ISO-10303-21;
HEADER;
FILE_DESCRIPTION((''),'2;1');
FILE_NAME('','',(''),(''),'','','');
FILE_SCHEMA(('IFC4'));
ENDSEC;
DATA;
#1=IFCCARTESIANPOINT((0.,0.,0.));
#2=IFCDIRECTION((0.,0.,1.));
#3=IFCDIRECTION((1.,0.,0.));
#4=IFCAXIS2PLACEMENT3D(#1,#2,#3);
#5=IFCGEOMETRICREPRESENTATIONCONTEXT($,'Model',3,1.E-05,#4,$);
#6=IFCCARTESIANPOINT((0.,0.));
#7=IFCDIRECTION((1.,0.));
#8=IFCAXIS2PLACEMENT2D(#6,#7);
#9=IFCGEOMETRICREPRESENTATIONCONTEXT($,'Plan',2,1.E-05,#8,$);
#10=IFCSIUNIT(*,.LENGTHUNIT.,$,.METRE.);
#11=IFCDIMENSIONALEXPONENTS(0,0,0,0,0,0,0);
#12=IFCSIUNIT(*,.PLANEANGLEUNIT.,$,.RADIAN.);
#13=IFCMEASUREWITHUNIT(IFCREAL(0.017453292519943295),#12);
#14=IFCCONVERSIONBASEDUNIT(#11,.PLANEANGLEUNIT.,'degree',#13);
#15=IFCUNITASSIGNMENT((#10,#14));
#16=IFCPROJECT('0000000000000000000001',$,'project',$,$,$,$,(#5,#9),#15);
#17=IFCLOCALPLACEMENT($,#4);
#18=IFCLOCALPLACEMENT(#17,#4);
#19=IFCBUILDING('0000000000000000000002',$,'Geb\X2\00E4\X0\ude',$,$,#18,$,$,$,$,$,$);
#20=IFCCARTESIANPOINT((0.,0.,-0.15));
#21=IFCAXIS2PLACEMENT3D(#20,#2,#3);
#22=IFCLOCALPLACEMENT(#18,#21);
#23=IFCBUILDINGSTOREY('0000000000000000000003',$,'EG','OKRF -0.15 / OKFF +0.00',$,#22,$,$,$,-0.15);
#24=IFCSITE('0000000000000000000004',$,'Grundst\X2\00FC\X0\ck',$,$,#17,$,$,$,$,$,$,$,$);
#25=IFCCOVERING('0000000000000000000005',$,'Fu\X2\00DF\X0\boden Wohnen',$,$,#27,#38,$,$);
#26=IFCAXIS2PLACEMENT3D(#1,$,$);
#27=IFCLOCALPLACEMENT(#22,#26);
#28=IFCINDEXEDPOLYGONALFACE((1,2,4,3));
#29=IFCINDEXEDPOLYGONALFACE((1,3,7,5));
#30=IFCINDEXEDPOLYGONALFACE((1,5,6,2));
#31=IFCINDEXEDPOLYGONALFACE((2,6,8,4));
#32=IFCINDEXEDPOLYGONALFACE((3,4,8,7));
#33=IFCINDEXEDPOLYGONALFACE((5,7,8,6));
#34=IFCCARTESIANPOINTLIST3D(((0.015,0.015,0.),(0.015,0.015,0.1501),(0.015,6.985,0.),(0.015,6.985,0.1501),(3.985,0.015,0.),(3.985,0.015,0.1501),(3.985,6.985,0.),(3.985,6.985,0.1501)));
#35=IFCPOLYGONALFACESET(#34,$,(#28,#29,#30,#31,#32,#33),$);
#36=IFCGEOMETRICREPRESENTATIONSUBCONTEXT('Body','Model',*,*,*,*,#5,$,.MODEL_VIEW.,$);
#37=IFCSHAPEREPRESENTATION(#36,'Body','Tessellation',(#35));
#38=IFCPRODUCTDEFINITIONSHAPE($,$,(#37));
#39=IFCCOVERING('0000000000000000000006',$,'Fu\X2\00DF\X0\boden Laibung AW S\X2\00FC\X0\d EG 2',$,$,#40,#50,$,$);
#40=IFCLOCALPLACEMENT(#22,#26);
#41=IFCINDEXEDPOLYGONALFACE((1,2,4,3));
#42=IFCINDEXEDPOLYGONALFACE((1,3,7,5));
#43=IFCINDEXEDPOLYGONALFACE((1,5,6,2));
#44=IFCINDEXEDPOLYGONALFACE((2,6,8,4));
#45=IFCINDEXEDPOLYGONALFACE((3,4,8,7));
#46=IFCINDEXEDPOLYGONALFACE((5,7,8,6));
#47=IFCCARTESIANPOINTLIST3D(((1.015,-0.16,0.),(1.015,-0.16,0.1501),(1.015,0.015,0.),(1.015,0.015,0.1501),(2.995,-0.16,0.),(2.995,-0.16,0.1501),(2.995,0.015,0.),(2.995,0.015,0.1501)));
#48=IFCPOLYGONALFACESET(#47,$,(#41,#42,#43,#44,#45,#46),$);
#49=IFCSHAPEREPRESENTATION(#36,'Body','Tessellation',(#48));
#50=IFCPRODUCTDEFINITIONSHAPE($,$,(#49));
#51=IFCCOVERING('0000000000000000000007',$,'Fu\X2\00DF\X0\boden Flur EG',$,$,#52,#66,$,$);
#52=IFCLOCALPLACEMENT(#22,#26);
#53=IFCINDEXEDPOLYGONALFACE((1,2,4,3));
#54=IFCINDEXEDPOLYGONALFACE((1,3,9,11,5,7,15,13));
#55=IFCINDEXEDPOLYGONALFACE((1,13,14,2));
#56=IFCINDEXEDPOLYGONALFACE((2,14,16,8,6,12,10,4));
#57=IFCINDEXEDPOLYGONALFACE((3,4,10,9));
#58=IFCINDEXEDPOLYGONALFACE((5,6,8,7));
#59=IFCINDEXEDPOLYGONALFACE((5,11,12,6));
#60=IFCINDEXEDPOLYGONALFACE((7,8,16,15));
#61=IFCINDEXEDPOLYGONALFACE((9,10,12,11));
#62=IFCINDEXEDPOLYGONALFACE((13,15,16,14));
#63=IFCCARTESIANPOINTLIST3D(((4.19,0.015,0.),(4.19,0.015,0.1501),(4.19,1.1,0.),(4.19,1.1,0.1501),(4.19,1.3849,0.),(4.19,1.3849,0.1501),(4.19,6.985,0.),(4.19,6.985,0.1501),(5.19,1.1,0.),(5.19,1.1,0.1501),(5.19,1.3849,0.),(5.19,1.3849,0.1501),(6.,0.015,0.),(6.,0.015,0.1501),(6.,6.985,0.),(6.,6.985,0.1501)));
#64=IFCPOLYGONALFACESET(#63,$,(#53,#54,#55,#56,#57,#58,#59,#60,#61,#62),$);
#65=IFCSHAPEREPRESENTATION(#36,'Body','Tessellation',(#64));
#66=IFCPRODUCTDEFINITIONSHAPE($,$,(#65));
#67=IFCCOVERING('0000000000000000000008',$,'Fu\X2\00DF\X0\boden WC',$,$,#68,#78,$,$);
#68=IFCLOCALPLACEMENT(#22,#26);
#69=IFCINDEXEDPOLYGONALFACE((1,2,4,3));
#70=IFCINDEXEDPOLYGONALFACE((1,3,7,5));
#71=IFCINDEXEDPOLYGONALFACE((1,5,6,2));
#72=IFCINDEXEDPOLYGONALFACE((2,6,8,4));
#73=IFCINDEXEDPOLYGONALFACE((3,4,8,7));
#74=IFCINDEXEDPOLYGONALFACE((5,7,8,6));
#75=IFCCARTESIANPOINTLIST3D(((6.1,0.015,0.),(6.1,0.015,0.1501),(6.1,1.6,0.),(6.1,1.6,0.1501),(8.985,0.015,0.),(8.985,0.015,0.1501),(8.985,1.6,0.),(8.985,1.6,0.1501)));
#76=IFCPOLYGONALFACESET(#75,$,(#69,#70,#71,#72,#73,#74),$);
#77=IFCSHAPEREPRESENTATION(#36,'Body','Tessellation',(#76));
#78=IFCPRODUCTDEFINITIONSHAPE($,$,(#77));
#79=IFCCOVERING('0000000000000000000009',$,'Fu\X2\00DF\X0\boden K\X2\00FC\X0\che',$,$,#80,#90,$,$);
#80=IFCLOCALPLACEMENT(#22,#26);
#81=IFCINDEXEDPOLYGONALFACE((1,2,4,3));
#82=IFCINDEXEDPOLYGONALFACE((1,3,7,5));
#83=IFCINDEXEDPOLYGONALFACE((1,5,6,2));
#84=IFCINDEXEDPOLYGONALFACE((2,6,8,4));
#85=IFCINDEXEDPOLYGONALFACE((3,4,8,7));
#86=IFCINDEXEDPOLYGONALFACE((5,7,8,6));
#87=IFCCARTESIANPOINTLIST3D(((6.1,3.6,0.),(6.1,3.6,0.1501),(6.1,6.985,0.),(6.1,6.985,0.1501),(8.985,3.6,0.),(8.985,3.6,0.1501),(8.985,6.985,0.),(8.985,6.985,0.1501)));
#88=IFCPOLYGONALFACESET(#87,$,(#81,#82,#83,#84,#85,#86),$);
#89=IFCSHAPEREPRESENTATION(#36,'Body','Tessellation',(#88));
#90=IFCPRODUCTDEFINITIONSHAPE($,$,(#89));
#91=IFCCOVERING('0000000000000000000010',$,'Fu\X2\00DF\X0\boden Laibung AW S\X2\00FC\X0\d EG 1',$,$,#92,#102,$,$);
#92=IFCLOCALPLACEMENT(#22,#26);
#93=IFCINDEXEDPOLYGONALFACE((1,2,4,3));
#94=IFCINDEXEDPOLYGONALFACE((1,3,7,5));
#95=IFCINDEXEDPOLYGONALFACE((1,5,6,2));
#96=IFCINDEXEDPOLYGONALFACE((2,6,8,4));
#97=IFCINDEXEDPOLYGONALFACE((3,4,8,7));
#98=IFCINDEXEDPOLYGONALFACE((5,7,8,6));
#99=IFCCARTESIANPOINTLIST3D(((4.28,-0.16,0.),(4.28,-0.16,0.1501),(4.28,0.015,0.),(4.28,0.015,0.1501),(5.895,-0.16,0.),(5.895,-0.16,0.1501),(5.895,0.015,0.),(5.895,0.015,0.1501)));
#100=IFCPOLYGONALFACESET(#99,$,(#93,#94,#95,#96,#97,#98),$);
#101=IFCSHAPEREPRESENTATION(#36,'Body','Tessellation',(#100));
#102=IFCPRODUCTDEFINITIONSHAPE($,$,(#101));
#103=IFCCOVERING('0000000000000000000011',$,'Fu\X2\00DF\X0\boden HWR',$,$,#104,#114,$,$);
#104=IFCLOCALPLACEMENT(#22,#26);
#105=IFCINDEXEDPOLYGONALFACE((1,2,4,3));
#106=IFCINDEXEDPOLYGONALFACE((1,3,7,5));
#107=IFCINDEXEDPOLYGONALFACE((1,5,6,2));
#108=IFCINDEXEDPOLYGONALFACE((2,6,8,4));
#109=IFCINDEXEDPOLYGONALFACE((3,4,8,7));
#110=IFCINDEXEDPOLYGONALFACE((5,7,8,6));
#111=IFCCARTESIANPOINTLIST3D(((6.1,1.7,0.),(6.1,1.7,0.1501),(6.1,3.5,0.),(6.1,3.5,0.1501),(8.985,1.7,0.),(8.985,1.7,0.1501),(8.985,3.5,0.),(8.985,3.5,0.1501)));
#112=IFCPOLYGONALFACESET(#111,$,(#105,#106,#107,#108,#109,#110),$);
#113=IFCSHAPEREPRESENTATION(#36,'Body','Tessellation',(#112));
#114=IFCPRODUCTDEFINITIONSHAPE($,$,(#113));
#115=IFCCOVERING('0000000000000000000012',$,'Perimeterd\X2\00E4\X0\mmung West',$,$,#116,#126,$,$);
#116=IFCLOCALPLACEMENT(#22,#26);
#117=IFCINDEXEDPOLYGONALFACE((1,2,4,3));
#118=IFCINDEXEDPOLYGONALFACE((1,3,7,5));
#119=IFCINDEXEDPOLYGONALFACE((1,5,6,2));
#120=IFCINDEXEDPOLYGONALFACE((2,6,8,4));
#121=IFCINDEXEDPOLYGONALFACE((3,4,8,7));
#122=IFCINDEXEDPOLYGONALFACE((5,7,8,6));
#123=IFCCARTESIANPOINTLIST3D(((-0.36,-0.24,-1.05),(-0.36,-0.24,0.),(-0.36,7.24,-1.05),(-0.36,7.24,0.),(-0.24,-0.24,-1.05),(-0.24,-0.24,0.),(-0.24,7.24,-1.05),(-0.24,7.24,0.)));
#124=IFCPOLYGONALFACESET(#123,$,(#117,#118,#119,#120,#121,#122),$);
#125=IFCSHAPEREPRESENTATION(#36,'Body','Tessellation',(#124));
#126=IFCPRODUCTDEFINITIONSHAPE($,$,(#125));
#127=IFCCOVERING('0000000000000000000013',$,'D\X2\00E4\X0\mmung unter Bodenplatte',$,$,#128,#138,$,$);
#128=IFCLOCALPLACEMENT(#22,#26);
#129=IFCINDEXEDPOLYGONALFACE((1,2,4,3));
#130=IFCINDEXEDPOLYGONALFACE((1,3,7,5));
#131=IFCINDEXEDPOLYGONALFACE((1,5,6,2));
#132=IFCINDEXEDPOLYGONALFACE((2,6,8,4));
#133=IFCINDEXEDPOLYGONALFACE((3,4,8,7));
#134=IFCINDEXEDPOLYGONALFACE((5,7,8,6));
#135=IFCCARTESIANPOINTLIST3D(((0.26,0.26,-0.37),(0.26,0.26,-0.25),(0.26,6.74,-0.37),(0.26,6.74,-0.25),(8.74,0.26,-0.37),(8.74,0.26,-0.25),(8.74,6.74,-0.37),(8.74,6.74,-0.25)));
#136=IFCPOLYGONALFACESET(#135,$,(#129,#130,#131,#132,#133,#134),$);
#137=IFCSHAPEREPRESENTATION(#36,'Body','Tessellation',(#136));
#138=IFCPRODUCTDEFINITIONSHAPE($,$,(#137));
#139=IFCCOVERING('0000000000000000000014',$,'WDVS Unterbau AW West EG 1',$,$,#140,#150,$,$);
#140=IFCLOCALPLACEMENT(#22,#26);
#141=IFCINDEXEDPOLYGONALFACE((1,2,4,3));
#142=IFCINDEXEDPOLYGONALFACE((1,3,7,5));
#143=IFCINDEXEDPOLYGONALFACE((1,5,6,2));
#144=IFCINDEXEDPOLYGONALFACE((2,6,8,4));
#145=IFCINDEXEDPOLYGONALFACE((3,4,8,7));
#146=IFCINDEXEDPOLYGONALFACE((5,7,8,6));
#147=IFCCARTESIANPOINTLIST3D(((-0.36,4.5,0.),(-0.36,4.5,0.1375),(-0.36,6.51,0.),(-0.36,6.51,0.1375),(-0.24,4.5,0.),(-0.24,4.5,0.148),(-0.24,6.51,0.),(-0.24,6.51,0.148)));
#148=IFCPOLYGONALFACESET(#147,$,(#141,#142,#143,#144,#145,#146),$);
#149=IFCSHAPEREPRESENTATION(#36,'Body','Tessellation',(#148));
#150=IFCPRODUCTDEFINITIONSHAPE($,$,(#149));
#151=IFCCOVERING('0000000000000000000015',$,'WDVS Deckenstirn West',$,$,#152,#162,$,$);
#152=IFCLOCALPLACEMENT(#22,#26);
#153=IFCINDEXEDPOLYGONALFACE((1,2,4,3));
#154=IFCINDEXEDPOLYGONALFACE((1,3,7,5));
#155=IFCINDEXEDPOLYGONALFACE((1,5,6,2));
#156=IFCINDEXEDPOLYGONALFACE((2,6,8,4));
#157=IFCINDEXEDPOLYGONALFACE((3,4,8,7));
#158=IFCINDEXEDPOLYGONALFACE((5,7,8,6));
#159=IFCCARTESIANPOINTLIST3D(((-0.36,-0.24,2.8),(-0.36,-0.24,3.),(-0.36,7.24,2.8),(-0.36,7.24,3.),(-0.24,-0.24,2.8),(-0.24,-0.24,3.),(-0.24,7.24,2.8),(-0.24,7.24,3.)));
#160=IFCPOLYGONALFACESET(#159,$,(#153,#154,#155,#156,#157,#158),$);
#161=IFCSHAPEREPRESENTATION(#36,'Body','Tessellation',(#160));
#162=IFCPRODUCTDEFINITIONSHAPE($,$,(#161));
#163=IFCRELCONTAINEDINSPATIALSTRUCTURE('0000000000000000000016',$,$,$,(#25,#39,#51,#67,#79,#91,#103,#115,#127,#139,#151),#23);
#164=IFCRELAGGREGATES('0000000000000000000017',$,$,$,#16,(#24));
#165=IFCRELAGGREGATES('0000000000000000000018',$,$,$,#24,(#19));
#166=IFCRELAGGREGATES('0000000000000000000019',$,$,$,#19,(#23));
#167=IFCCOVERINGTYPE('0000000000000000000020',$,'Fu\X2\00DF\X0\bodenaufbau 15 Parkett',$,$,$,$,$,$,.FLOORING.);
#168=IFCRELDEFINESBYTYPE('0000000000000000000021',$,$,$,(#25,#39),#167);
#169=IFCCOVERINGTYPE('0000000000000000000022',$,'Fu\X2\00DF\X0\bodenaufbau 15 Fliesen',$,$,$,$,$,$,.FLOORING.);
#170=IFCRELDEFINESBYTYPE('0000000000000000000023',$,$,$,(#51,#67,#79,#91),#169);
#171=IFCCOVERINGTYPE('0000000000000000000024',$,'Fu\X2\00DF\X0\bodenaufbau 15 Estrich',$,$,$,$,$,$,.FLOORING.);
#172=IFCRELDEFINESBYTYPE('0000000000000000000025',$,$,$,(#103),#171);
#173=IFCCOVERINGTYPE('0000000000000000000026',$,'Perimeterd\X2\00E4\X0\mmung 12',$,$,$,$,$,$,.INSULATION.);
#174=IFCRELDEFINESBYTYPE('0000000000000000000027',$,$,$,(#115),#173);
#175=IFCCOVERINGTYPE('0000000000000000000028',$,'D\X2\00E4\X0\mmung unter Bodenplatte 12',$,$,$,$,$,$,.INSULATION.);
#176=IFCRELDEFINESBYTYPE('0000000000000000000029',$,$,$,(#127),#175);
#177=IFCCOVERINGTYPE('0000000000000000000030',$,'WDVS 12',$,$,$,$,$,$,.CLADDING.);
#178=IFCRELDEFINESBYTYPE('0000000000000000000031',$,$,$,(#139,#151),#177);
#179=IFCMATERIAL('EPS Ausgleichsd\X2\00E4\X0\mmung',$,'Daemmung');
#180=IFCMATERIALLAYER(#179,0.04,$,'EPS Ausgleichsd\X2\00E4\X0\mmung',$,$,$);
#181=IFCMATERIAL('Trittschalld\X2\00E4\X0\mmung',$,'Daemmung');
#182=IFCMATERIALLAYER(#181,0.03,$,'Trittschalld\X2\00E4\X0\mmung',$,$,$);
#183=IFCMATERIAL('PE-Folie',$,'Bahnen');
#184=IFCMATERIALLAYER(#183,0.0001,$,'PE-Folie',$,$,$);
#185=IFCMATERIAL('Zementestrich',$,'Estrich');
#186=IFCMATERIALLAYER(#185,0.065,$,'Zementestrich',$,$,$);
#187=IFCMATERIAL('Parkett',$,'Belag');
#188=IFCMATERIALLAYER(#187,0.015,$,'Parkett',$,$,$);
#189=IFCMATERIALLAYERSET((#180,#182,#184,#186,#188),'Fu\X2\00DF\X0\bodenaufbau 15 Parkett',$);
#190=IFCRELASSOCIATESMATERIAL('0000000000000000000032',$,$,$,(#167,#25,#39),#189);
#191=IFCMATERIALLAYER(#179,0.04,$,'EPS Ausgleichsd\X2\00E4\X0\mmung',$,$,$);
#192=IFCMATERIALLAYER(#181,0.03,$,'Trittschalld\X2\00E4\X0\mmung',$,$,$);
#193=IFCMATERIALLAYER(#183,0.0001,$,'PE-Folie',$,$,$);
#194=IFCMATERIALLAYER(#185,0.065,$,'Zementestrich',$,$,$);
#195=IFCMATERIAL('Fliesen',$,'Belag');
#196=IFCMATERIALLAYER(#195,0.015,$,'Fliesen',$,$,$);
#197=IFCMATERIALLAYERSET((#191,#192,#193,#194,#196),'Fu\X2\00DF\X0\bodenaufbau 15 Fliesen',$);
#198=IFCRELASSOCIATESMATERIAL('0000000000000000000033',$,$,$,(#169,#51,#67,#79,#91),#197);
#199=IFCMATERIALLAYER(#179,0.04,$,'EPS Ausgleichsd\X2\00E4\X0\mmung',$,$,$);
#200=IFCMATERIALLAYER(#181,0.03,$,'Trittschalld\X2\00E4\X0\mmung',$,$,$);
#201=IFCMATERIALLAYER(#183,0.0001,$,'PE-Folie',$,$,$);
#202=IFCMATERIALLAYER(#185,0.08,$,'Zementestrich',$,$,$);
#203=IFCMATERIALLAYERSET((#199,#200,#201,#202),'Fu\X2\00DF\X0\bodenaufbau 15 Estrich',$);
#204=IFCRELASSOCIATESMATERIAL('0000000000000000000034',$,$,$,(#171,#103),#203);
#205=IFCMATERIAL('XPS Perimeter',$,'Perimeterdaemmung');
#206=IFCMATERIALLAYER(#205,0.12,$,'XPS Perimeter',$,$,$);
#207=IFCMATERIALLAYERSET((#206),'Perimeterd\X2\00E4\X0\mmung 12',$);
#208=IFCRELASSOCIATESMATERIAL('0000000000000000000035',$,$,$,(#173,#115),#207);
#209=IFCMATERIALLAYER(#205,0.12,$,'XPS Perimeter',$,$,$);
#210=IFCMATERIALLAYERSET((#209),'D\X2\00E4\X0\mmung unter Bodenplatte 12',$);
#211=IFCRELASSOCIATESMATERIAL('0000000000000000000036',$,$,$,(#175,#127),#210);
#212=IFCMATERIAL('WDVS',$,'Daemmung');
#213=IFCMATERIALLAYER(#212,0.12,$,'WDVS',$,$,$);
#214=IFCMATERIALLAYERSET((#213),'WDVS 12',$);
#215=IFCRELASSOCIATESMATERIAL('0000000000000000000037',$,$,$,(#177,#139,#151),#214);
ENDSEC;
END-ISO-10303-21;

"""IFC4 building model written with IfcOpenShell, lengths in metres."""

from ifc_helpers import new_model, entity, si_unit, converted_unit, frame, origin_with_axes, origin_2d_with_axis, place, context, subcontext, project, spatial, polyline, indexed_curve, outline, extrude, material, layer, layer_set, layer_usage, type_object, element, save


model = new_model("IFC4")

# Units and contexts
model_context = context("Model", 3, precision=1e-05, world=origin_with_axes())
plan_context = context("Plan", 2, precision=1e-05, world=origin_2d_with_axis())
body_context_1 = subcontext(model_context, "Body", "Model", "MODEL_VIEW")
ifc_project = project(units=[si_unit("LENGTHUNIT", "METRE"), converted_unit("PLANEANGLEUNIT", "degree", entity("IfcReal", 0.017453292519943295), si_unit("PLANEANGLEUNIT", "RADIAN"), dimensions=[0, 0, 0, 0, 0, 0, 0])], contexts=[model_context, plan_context])

# Site, building, storey
site_placement = place(None, origin_with_axes())
site = spatial("IfcSite", under=ifc_project, at=site_placement, Name="Grundstück")
building_placement = place(site_placement, origin_with_axes())
building = spatial("IfcBuilding", under=site, at=building_placement, Name="Gebäude")
storey_placement = place(building_placement, frame((0.0, 0.0, -0.15), z_axis=(0.0, 0.0, 1.0), x_axis=(1.0, 0.0, 0.0)))
storey = spatial("IfcBuildingStorey", under=building, at=storey_placement, Name="EG", Description="OKRF -0.15 / OKFF +0.00", Elevation=-0.15)

# Shared definitions
ifc_material_1 = material(Name="WDVS", Category="Daemmung")
ifc_material_2 = material(Name="XPS Perimeter", Category="Perimeterdaemmung")

# Coverings
ifc_material_3 = material(Name="EPS Ausgleichsdämmung", Category="Daemmung")
ifc_layer_1 = layer(ifc_material_3, 0.04, Name="EPS Ausgleichsdämmung")
ifc_material_4 = material(Name="Trittschalldämmung", Category="Daemmung")
ifc_layer_2 = layer(ifc_material_4, 0.03, Name="Trittschalldämmung")
ifc_material_5 = material(Name="PE-Folie", Category="Bahnen")
ifc_layer_3 = layer(ifc_material_5, 0.0001, Name="PE-Folie")
ifc_material_6 = material(Name="Zementestrich", Category="Estrich")
ifc_layer_4 = layer(ifc_material_6, 0.065, Name="Zementestrich")
ifc_material_7 = material(Name="Parkett", Category="Belag")
ifc_layer_5 = layer(ifc_material_7, 0.015, Name="Parkett")
ifc_layer_set_1 = layer_set([ifc_layer_1, ifc_layer_2, ifc_layer_3, ifc_layer_4, ifc_layer_5], Name="Fußbodenaufbau 15 Parkett")
ifc_layer_usage_1 = layer_usage(ifc_layer_set_1, "AXIS3", "POSITIVE", 0.0)
covering_type_1 = type_object("IfcCoveringType", Name="Fußbodenaufbau 15 Parkett", PredefinedType="FLOORING", material=ifc_layer_set_1)
covering_1_placement = place(storey_placement, origin_with_axes())
element("IfcCovering", 1, at=covering_1_placement, inside=storey, type_object=covering_type_1, material=ifc_layer_usage_1, Name="Fußboden Wohnen", context=body_context_1, shape_type="SweptSolid", body=[
    extrude(outline(indexed_curve([(0.015, 0.015), (3.985, 0.015), (3.985, 6.985), (0.015, 6.985)])), None, (0.0, 0.0, 1.0), 0.1501),
])
ifc_layer_usage_2 = layer_usage(ifc_layer_set_1, "AXIS3", "POSITIVE", 0.0)
covering_2_placement = place(storey_placement, origin_with_axes())
element("IfcCovering", 2, at=covering_2_placement, inside=storey, type_object=covering_type_1, material=ifc_layer_usage_2, Name="Fußboden Laibung AW Süd EG 2", context=body_context_1, shape_type="SweptSolid", body=[
    extrude(outline(indexed_curve([(1.015, -0.16), (2.995, -0.16), (2.995, 0.015), (1.015, 0.015)])), None, (0.0, 0.0, 1.0), 0.1501),
])

# Covering, opening
ifc_layer_6 = layer(ifc_material_3, 0.04, Name="EPS Ausgleichsdämmung")
ifc_layer_7 = layer(ifc_material_4, 0.03, Name="Trittschalldämmung")
ifc_layer_8 = layer(ifc_material_5, 0.0001, Name="PE-Folie")
ifc_layer_9 = layer(ifc_material_6, 0.065, Name="Zementestrich")
ifc_material_8 = material(Name="Fliesen", Category="Belag")
ifc_layer_10 = layer(ifc_material_8, 0.015, Name="Fliesen")
ifc_layer_set_2 = layer_set([ifc_layer_6, ifc_layer_7, ifc_layer_8, ifc_layer_9, ifc_layer_10], Name="Fußbodenaufbau 15 Fliesen")
ifc_layer_usage_3 = layer_usage(ifc_layer_set_2, "AXIS3", "POSITIVE", 0.0)
covering_type_2 = type_object("IfcCoveringType", Name="Fußbodenaufbau 15 Fliesen", PredefinedType="FLOORING", material=ifc_layer_set_2)
covering_3_placement = place(storey_placement, origin_with_axes())
covering_3 = element("IfcCovering", 3, at=covering_3_placement, inside=storey, type_object=covering_type_2, material=ifc_layer_usage_3, Name="Fußboden Flur EG", context=body_context_1, shape_type="SweptSolid", body=[
    extrude(outline(indexed_curve([(4.19, 0.015), (6.0, 0.015), (6.0, 6.985), (4.19, 6.985)])), None, (0.0, 0.0, 1.0), 0.1501),
])
opening_1_placement = place(covering_3_placement, frame((4.19, 1.1, -0.05), z_axis=(0.0, 0.0, 1.0), x_axis=(1.0, 0.0, 0.0)))
element("IfcOpeningElement", 4, at=opening_1_placement, cuts=covering_3, context=body_context_1, shape_type="SweptSolid", body=[
    extrude(outline(indexed_curve([(0.0, 0.0), (0.0, 0.2849), (1.0, 0.2849), (1.0, 0.0), (0.0, 0.0)], self_intersect=False)), origin_with_axes(), (0.0, 0.0, 1.0), 0.2501),
])

# Coverings
ifc_layer_usage_4 = layer_usage(ifc_layer_set_2, "AXIS3", "POSITIVE", 0.0)
covering_4_placement = place(storey_placement, origin_with_axes())
element("IfcCovering", 5, at=covering_4_placement, inside=storey, type_object=covering_type_2, material=ifc_layer_usage_4, Name="Fußboden WC", context=body_context_1, shape_type="SweptSolid", body=[
    extrude(outline(indexed_curve([(6.1, 0.015), (8.985, 0.015), (8.985, 1.6), (6.1, 1.6)])), None, (0.0, 0.0, 1.0), 0.1501),
])
ifc_layer_usage_5 = layer_usage(ifc_layer_set_2, "AXIS3", "POSITIVE", 0.0)
covering_5_placement = place(storey_placement, origin_with_axes())
element("IfcCovering", 6, at=covering_5_placement, inside=storey, type_object=covering_type_2, material=ifc_layer_usage_5, Name="Fußboden Küche", context=body_context_1, shape_type="SweptSolid", body=[
    extrude(outline(indexed_curve([(6.1, 3.6), (8.985, 3.6), (8.985, 6.985), (6.1, 6.985)])), None, (0.0, 0.0, 1.0), 0.1501),
])
ifc_layer_usage_6 = layer_usage(ifc_layer_set_2, "AXIS3", "POSITIVE", 0.0)
covering_6_placement = place(storey_placement, origin_with_axes())
element("IfcCovering", 7, at=covering_6_placement, inside=storey, type_object=covering_type_2, material=ifc_layer_usage_6, Name="Fußboden Laibung AW Süd EG 1", context=body_context_1, shape_type="SweptSolid", body=[
    extrude(outline(indexed_curve([(4.28, -0.16), (5.895, -0.16), (5.895, 0.015), (4.28, 0.015)])), None, (0.0, 0.0, 1.0), 0.1501),
])
ifc_layer_11 = layer(ifc_material_3, 0.04, Name="EPS Ausgleichsdämmung")
ifc_layer_12 = layer(ifc_material_4, 0.03, Name="Trittschalldämmung")
ifc_layer_13 = layer(ifc_material_5, 0.0001, Name="PE-Folie")
ifc_layer_14 = layer(ifc_material_6, 0.08, Name="Zementestrich")
ifc_layer_set_3 = layer_set([ifc_layer_11, ifc_layer_12, ifc_layer_13, ifc_layer_14], Name="Fußbodenaufbau 15 Estrich")
ifc_layer_usage_7 = layer_usage(ifc_layer_set_3, "AXIS3", "POSITIVE", 0.0)
covering_type_3 = type_object("IfcCoveringType", Name="Fußbodenaufbau 15 Estrich", PredefinedType="FLOORING", material=ifc_layer_set_3)
covering_7_placement = place(storey_placement, origin_with_axes())
element("IfcCovering", 8, at=covering_7_placement, inside=storey, type_object=covering_type_3, material=ifc_layer_usage_7, Name="Fußboden HWR", context=body_context_1, shape_type="SweptSolid", body=[
    extrude(outline(indexed_curve([(6.1, 1.7), (8.985, 1.7), (8.985, 3.5), (6.1, 3.5)])), None, (0.0, 0.0, 1.0), 0.1501),
])
ifc_layer_15 = layer(ifc_material_2, 0.12, Name="XPS Perimeter")
ifc_layer_set_4 = layer_set([ifc_layer_15], Name="Perimeterdämmung 12")
ifc_layer_usage_8 = layer_usage(ifc_layer_set_4, "AXIS2", "POSITIVE", 0.0)
covering_type_4 = type_object("IfcCoveringType", Name="Perimeterdämmung 12", PredefinedType="INSULATION", material=ifc_layer_set_4)
covering_8_placement = place(storey_placement, frame((-0.24, -0.24, -1.05), z_axis=(0.0, 0.0, 1.0), x_axis=(0.0, 1.0, 0.0)))
element("IfcCovering", 9, at=covering_8_placement, inside=storey, type_object=covering_type_4, material=ifc_layer_usage_8, Name="Perimeterdämmung West", context=body_context_1, shape_type="SweptSolid", body=[
    extrude(outline(indexed_curve([(0.0, 0.0), (0.0, 0.12), (7.48, 0.12), (7.48, 0.0), (0.0, 0.0)], self_intersect=False)), origin_with_axes(), (0.0, 0.0, 1.0), 1.05),
])
ifc_layer_16 = layer(ifc_material_2, 0.12, Name="XPS Perimeter")
ifc_layer_set_5 = layer_set([ifc_layer_16], Name="Dämmung unter Bodenplatte 12")
ifc_layer_usage_9 = layer_usage(ifc_layer_set_5, "AXIS3", "POSITIVE", 0.0)
covering_type_5 = type_object("IfcCoveringType", Name="Dämmung unter Bodenplatte 12", PredefinedType="INSULATION", material=ifc_layer_set_5)
covering_9_placement = place(storey_placement, frame((0.0, 0.0, -0.37), z_axis=(0.0, 0.0, 1.0), x_axis=(1.0, 0.0, 0.0)))
element("IfcCovering", 10, at=covering_9_placement, inside=storey, type_object=covering_type_5, material=ifc_layer_usage_9, Name="Dämmung unter Bodenplatte", context=body_context_1, shape_type="SweptSolid", body=[
    extrude(outline(indexed_curve([(0.26, 0.26), (8.74, 0.26), (8.74, 6.74), (0.26, 6.74)])), None, (0.0, 0.0, 1.0), 0.12),
])
ifc_layer_17 = layer(ifc_material_1, 0.12, Name="WDVS")
ifc_layer_set_6 = layer_set([ifc_layer_17], Name="WDVS 12")
ifc_layer_usage_10 = layer_usage(ifc_layer_set_6, "AXIS2", "POSITIVE", 0.24)
covering_type_6 = type_object("IfcCoveringType", Name="WDVS 12", PredefinedType="CLADDING", material=ifc_layer_set_6)
covering_10_placement = place(storey_placement, frame((0.0, 0.0, 0.0), z_axis=(0.0, 0.0, 1.0), x_axis=(0.0, 1.0, 0.0)))
element("IfcCovering", 11, at=covering_10_placement, inside=storey, type_object=covering_type_6, material=ifc_layer_usage_10, Name="WDVS Unterbau AW West EG 1", context=body_context_1, shape_type="SweptSolid", body=[
    extrude(outline(polyline([(0.24, 0.0), (0.36, 0.0), (0.36, 0.1375), (0.24, 0.148), (0.24, 0.0)])), frame((4.5, 0.0, 0.0), z_axis=(1.0, 0.0, 0.0), x_axis=(0.0, 1.0, 0.0)), (0.0, 0.0, 1.0), 2.01),
])
ifc_layer_usage_11 = layer_usage(ifc_layer_set_6, "AXIS2", "POSITIVE", 0.0)
covering_11_placement = place(storey_placement, frame((-0.24, -0.24, 2.8), z_axis=(0.0, 0.0, 1.0), x_axis=(0.0, 1.0, 0.0)))
element("IfcCovering", 12, at=covering_11_placement, inside=storey, type_object=covering_type_6, material=ifc_layer_usage_11, Name="WDVS Deckenstirn West", context=body_context_1, shape_type="SweptSolid", body=[
    extrude(outline(indexed_curve([(0.0, 0.0), (0.0, 0.12), (7.48, 0.12), (7.48, 0.0), (0.0, 0.0)], self_intersect=False)), origin_with_axes(), (0.0, 0.0, 1.0), 0.2),
])

save(model, "model.ifc")
